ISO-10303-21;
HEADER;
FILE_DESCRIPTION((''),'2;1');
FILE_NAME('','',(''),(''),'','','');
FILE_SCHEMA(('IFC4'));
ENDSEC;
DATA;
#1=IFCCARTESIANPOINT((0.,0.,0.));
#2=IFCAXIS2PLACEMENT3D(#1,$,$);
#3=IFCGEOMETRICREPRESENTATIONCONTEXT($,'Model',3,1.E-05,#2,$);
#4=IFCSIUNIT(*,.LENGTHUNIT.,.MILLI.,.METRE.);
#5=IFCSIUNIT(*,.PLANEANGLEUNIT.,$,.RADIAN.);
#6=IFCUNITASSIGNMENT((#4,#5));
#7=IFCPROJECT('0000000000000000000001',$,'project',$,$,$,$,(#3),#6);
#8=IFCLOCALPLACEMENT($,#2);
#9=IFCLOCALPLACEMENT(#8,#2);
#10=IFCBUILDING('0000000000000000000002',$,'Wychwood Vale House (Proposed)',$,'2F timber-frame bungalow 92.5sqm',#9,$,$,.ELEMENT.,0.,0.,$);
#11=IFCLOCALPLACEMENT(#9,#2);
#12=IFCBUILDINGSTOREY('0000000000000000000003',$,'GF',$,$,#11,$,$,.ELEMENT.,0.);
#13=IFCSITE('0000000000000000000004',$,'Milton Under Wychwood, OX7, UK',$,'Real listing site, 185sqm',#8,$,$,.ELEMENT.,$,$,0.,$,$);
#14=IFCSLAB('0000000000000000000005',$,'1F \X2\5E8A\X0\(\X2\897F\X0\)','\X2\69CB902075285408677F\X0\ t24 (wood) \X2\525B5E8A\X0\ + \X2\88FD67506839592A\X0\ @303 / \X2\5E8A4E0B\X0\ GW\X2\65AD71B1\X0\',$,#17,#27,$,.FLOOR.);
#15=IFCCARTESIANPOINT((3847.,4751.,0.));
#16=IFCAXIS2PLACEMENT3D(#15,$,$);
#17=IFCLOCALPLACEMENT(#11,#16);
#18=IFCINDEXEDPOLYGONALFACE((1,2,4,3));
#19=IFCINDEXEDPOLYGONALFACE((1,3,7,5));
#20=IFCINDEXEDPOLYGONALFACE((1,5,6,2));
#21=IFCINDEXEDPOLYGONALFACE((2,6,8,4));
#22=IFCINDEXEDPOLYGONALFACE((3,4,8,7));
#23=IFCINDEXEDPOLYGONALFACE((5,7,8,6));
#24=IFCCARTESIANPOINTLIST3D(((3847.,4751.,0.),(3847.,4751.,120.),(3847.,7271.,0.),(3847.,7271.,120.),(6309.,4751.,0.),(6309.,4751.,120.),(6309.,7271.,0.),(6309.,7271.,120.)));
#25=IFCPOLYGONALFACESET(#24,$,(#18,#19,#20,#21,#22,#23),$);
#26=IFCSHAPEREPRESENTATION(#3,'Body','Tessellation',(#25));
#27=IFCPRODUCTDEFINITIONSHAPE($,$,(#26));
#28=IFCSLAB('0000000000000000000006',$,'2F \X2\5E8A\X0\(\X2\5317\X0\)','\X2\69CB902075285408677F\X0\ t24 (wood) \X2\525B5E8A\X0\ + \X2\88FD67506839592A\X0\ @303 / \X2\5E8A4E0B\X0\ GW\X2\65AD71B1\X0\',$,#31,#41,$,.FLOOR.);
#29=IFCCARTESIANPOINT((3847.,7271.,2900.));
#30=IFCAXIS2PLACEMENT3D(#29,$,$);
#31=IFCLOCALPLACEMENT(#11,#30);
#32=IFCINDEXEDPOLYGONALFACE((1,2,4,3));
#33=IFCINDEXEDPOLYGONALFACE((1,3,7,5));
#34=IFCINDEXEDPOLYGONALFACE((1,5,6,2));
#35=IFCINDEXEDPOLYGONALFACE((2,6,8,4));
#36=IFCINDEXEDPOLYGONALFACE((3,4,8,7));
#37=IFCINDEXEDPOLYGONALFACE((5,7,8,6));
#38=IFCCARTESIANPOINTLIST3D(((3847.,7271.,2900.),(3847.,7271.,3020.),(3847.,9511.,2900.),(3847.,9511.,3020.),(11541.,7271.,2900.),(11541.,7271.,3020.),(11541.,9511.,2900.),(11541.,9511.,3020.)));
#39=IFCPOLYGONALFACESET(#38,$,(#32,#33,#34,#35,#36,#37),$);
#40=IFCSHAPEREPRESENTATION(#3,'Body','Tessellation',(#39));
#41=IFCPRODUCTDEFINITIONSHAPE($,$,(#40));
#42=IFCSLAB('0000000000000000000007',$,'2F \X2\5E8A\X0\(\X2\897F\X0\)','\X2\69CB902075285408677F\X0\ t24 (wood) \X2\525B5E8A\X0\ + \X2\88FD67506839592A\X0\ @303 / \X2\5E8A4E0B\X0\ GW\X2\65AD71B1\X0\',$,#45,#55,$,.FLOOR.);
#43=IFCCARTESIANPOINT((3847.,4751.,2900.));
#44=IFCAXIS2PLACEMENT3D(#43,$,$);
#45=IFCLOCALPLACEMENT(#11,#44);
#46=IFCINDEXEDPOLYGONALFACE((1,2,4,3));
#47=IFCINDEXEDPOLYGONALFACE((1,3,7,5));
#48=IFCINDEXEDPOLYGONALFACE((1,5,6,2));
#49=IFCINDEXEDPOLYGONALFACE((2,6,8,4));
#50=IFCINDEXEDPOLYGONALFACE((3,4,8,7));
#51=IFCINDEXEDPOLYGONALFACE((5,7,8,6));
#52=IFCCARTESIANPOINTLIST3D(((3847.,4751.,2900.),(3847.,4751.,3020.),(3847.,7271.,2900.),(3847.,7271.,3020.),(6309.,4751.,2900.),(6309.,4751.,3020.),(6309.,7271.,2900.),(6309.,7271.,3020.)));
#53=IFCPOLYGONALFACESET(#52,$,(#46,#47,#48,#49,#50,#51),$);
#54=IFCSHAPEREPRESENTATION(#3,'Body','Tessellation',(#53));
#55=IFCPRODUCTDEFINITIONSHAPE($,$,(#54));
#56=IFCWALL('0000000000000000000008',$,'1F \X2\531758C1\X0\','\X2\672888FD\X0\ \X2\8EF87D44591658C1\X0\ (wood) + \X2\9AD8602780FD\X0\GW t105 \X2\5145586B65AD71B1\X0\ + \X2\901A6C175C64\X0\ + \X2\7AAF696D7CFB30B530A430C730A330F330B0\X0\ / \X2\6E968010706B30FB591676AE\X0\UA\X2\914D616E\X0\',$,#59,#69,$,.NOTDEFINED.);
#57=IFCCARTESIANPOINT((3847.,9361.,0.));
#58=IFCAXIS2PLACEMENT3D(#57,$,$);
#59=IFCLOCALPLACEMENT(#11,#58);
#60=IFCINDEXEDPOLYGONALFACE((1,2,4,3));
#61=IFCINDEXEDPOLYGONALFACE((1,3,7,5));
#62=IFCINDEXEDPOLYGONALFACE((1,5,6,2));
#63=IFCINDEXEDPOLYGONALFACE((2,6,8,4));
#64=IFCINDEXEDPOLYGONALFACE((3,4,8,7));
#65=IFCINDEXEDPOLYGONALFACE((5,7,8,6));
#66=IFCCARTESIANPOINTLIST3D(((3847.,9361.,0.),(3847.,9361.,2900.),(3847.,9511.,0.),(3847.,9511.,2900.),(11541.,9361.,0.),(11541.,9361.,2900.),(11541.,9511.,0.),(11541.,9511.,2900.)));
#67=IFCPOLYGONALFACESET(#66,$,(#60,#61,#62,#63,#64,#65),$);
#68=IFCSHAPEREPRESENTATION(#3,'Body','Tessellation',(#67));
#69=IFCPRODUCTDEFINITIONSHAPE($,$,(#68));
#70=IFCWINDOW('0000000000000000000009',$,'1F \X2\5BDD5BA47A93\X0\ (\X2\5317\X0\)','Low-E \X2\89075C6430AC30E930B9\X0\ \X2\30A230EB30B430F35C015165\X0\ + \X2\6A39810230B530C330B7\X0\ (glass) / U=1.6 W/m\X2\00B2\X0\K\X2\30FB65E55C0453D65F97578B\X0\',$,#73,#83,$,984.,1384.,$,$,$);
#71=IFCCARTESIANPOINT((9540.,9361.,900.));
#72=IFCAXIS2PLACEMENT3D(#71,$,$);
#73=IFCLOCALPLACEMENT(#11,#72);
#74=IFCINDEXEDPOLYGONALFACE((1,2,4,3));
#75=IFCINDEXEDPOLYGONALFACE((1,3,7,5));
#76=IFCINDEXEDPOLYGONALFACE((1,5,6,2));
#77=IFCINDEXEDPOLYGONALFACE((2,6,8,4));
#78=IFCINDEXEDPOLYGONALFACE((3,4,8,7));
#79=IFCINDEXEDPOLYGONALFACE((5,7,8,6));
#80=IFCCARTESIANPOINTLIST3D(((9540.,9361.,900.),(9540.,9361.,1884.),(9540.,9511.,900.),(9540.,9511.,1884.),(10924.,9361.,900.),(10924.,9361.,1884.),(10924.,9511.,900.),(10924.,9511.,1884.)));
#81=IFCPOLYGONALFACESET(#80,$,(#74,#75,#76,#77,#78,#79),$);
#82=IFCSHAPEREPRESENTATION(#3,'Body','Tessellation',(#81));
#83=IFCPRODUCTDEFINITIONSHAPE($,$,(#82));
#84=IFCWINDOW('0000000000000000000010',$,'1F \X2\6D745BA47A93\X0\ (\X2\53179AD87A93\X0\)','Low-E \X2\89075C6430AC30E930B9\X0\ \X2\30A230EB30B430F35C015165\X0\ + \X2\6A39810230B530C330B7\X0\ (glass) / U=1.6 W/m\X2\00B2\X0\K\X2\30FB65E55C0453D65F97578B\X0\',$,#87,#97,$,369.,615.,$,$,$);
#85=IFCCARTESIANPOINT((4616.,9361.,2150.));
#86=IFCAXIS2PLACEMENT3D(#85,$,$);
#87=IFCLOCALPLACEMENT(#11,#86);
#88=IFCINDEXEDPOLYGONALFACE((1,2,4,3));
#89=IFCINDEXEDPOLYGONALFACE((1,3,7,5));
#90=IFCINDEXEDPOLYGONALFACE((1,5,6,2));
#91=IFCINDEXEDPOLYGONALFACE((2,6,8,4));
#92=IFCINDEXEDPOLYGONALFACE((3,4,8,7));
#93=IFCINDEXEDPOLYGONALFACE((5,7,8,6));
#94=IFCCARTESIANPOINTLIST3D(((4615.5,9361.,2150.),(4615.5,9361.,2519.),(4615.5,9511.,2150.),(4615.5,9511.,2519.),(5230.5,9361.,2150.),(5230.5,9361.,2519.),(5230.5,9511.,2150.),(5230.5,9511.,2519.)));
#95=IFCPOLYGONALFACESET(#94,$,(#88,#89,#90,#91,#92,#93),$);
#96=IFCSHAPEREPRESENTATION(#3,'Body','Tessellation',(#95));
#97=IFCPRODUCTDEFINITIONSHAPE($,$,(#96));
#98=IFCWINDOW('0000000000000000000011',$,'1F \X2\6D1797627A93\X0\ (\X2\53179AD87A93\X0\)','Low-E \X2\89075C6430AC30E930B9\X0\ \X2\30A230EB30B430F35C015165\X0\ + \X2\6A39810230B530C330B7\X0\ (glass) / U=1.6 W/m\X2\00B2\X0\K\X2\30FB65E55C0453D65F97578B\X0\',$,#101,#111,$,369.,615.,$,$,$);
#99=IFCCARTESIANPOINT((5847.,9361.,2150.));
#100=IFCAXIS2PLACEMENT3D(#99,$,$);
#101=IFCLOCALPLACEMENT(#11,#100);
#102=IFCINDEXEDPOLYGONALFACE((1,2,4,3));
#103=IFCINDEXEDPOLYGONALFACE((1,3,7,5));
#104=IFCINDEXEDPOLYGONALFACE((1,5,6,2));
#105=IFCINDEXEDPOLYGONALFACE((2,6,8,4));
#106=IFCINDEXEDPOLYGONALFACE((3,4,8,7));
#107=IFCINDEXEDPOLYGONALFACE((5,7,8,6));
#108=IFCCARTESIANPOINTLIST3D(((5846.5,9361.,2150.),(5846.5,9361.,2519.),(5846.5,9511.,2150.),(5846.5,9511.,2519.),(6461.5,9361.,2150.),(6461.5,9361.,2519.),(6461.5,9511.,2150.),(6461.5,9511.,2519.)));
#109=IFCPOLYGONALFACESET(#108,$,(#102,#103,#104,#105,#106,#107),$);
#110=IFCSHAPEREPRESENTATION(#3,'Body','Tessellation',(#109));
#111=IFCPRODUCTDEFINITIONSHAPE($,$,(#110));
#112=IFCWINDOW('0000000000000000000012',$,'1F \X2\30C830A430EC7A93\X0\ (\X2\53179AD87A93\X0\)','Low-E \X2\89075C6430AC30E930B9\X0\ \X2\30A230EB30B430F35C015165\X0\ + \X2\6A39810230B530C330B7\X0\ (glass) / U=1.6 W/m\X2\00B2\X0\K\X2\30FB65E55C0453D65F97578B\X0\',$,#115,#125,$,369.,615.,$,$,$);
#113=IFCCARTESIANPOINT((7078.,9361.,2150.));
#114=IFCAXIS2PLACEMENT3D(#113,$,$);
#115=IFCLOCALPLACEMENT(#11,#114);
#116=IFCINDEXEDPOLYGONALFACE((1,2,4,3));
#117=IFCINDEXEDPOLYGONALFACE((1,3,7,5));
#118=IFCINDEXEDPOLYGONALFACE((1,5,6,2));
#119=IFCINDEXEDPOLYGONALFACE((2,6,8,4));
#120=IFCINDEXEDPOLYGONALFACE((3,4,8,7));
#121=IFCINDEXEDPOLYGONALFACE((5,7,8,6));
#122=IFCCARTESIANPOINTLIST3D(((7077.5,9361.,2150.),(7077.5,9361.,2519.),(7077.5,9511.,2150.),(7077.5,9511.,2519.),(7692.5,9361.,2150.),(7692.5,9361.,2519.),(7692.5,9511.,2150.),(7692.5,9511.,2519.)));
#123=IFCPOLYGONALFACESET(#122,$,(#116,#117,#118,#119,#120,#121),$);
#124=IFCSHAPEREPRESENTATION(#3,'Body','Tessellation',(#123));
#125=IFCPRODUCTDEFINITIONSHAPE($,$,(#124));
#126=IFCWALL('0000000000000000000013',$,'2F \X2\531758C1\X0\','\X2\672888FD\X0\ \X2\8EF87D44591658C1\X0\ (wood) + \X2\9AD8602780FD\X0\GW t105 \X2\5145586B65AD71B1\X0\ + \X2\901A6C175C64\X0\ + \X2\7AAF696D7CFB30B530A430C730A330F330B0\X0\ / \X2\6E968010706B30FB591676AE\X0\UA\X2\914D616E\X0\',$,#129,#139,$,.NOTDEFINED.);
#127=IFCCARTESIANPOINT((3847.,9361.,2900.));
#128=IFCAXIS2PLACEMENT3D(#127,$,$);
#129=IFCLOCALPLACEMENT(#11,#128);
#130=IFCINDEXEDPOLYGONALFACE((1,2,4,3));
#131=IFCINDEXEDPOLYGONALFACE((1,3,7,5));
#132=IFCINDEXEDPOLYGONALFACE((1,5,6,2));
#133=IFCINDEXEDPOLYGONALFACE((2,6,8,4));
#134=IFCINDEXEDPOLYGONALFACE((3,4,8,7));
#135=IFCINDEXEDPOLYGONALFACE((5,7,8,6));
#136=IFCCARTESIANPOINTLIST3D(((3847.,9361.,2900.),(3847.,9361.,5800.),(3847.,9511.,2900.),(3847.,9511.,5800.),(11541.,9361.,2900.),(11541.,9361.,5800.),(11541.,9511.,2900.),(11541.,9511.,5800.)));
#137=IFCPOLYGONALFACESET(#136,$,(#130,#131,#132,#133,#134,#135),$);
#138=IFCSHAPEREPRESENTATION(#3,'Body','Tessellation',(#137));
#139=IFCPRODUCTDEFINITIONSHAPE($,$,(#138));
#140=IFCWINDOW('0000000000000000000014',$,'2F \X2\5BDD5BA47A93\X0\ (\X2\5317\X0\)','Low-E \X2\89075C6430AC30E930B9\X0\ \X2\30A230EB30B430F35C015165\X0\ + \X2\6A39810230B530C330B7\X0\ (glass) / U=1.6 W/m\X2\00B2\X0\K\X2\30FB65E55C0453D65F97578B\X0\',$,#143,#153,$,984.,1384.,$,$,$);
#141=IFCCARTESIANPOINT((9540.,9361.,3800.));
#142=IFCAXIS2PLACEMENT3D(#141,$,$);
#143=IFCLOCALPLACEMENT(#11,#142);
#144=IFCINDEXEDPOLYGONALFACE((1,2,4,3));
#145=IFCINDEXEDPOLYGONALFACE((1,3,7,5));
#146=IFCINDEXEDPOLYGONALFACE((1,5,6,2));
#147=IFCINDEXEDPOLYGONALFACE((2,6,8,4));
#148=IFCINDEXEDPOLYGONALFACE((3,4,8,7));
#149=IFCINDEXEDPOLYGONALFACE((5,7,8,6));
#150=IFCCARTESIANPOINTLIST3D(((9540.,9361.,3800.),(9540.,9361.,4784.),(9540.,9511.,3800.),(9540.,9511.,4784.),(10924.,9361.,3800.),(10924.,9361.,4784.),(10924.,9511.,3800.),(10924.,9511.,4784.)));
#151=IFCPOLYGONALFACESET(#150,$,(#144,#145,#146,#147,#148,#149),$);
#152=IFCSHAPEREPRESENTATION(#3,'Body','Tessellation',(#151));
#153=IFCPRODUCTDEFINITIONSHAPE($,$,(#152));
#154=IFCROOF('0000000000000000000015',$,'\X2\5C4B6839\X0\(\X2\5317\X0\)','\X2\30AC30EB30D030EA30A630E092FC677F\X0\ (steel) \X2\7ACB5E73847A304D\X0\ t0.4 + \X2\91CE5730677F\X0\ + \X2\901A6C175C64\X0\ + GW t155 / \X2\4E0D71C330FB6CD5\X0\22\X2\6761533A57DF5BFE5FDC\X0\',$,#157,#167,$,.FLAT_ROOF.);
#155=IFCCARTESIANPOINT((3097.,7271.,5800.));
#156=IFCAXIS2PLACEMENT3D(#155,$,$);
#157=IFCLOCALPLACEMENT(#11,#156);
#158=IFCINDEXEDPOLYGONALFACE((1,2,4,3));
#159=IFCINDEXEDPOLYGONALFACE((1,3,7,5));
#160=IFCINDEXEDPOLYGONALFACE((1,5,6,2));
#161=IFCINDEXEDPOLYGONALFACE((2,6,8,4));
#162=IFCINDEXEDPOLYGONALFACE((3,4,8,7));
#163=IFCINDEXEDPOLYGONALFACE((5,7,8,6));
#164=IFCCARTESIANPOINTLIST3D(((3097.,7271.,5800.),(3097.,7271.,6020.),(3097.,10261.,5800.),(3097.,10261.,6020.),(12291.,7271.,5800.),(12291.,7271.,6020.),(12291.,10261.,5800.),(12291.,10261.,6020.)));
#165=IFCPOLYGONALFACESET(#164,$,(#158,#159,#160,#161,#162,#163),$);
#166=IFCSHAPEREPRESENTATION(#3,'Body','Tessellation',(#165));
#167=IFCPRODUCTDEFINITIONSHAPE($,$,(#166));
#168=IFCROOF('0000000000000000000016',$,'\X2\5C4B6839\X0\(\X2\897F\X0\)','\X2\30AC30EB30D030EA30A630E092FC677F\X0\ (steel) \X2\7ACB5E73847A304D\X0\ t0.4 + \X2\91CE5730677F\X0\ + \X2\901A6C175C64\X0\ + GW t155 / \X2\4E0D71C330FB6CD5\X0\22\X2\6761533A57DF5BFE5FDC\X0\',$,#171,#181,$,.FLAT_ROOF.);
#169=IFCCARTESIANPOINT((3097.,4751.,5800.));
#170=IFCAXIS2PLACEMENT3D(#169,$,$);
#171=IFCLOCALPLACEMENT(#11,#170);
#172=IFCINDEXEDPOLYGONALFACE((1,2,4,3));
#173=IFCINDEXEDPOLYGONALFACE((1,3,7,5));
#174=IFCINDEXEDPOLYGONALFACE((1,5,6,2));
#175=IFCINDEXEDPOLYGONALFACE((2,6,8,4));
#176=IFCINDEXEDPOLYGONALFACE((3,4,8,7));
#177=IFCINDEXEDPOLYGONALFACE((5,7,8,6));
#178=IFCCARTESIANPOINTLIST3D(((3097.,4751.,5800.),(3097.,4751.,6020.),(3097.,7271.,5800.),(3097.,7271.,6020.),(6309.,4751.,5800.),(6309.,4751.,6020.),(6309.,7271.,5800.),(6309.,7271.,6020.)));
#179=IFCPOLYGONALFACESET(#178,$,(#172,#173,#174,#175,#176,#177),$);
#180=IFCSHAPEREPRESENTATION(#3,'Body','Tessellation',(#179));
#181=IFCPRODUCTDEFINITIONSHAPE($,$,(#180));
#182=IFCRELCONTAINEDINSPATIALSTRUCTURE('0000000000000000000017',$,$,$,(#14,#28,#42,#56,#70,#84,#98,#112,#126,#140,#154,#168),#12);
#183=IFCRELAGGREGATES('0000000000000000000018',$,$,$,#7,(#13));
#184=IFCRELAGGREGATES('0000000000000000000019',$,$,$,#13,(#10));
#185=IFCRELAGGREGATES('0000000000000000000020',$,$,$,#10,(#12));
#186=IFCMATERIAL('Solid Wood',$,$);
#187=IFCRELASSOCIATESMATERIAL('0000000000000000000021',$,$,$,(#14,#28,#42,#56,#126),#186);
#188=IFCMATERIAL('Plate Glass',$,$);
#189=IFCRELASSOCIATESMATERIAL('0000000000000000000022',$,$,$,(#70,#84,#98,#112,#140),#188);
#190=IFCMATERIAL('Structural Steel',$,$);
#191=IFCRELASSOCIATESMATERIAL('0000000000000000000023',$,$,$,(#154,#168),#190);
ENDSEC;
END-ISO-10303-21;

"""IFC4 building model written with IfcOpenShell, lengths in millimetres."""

from ifc_helpers import new_model, si_unit, frame, frame_2d, origin, place, context, project, spatial, rectangle, extrude, material, element, fill, save


model = new_model("IFC4")

# Units and contexts
model_context = context("Model", 3, precision=1e-05, world=origin())
ifc_project = project(units=[si_unit("LENGTHUNIT", "METRE", prefix="MILLI"), si_unit("PLANEANGLEUNIT", "RADIAN")], contexts=[model_context])

# Site, building, storey
site_placement = place(None, origin())
site = spatial("IfcSite", under=ifc_project, at=site_placement, Name="Milton Under Wychwood, OX7, UK", ObjectType="Real listing site, 185sqm", CompositionType="ELEMENT", RefElevation=0.0)
building_placement = place(site_placement, origin())
building = spatial("IfcBuilding", under=site, at=building_placement, Name="Wychwood Vale House (Proposed)", ObjectType="2F timber-frame bungalow 92.5sqm", CompositionType="ELEMENT", ElevationOfRefHeight=0.0, ElevationOfTerrain=0.0)
storey_placement = place(building_placement, origin())
storey = spatial("IfcBuildingStorey", under=building, at=storey_placement, Name="GF", CompositionType="ELEMENT", Elevation=0.0)

# Slabs
ifc_material_1 = material(Name="Solid Wood")
slab_1_placement = place(storey_placement, frame((3847.0, 4751.0, 0.0)))
element("IfcSlab", 1, at=slab_1_placement, inside=storey, material=ifc_material_1, Name="1F 床(西)", Description="構造用合板 t24 (wood) 剛床 + 製材根太 @303 / 床下 GW断熱", PredefinedType="FLOOR", context=model_context, shape_type="SweptSolid", body=[
    extrude(rectangle(XDim=2462.0, YDim=2520.0, at=frame_2d((1231.0, 1260.0))), frame((3847.0, 4751.0, 0.0)), (0.0, 0.0, 1.0), 120.0),
])
slab_2_placement = place(storey_placement, frame((3847.0, 7271.0, 2900.0)))
element("IfcSlab", 2, at=slab_2_placement, inside=storey, material=ifc_material_1, Name="2F 床(北)", Description="構造用合板 t24 (wood) 剛床 + 製材根太 @303 / 床下 GW断熱", PredefinedType="FLOOR", context=model_context, shape_type="SweptSolid", body=[
    extrude(rectangle(XDim=7694.0, YDim=2240.0, at=frame_2d((3847.0, 1120.0))), frame((3847.0, 7271.0, 2900.0)), (0.0, 0.0, 1.0), 120.0),
])
slab_3_placement = place(storey_placement, frame((3847.0, 4751.0, 2900.0)))
element("IfcSlab", 3, at=slab_3_placement, inside=storey, material=ifc_material_1, Name="2F 床(西)", Description="構造用合板 t24 (wood) 剛床 + 製材根太 @303 / 床下 GW断熱", PredefinedType="FLOOR", context=model_context, shape_type="SweptSolid", body=[
    extrude(rectangle(XDim=2462.0, YDim=2520.0, at=frame_2d((1231.0, 1260.0))), frame((3847.0, 4751.0, 2900.0)), (0.0, 0.0, 1.0), 120.0),
])

# Wall, openings, windows
wall_1_placement = place(storey_placement, frame((3847.0, 9361.0, 0.0)))
wall_1 = element("IfcWall", 4, at=wall_1_placement, inside=storey, material=ifc_material_1, Name="1F 北壁", Description="木製 軸組外壁 (wood) + 高性能GW t105 充填断熱 + 通気層 + 窯業系サイディング / 準耐火・外皮UA配慮", PredefinedType="NOTDEFINED", context=model_context, shape_type="SweptSolid", body=[
    extrude(rectangle(XDim=7694.0, YDim=150.0, at=frame_2d((3847.0, 75.0))), frame((3847.0, 9361.0, 0.0)), (0.0, 0.0, 1.0), 2900.0),
])
opening_1_placement = place(storey_placement, frame((9540.0, 9361.0, 900.0)))
opening_1 = element("IfcOpeningElement", 5, at=opening_1_placement, cuts=wall_1, PredefinedType="NOTDEFINED", context=model_context, shape_type="SweptSolid", body=[
    extrude(rectangle(XDim=1384.0, YDim=150.0, at=frame_2d((692.0, 75.0))), frame((9540.0, 9361.0, 900.0)), (0.0, 0.0, 1.0), 984.0),
])
opening_2_placement = place(storey_placement, frame((4616.0, 9361.0, 2150.0)))
opening_2 = element("IfcOpeningElement", 6, at=opening_2_placement, cuts=wall_1, PredefinedType="NOTDEFINED", context=model_context, shape_type="SweptSolid", body=[
    extrude(rectangle(XDim=615.0, YDim=150.0, at=frame_2d((307.0, 75.0))), frame((4616.0, 9361.0, 2150.0)), (0.0, 0.0, 1.0), 369.0),
])
opening_3_placement = place(storey_placement, frame((5847.0, 9361.0, 2150.0)))
opening_3 = element("IfcOpeningElement", 7, at=opening_3_placement, cuts=wall_1, PredefinedType="NOTDEFINED", context=model_context, shape_type="SweptSolid", body=[
    extrude(rectangle(XDim=615.0, YDim=150.0, at=frame_2d((307.0, 75.0))), frame((5847.0, 9361.0, 2150.0)), (0.0, 0.0, 1.0), 369.0),
])
opening_4_placement = place(storey_placement, frame((7078.0, 9361.0, 2150.0)))
opening_4 = element("IfcOpeningElement", 8, at=opening_4_placement, cuts=wall_1, PredefinedType="NOTDEFINED", context=model_context, shape_type="SweptSolid", body=[
    extrude(rectangle(XDim=615.0, YDim=150.0, at=frame_2d((307.0, 75.0))), frame((7078.0, 9361.0, 2150.0)), (0.0, 0.0, 1.0), 369.0),
])
ifc_material_2 = material(Name="Plate Glass")
window_1_placement = place(storey_placement, frame((9540.0, 9361.0, 900.0)))
window_1 = element("IfcWindow", 9, at=window_1_placement, inside=storey, material=ifc_material_2, Name="1F 寝室窓 (北)", Description="Low-E 複層ガラス アルゴン封入 + 樹脂サッシ (glass) / U=1.6 W/m²K・日射取得型", OverallHeight=984.0, OverallWidth=1384.0, context=model_context, shape_type="SweptSolid", body=[
    extrude(rectangle(XDim=1384.0, YDim=150.0, at=frame_2d((692.0, 75.0))), frame((9540.0, 9361.0, 900.0)), (0.0, 0.0, 1.0), 984.0),
])
fill(opening_1, window_1)
window_2_placement = place(storey_placement, frame((4616.0, 9361.0, 2150.0)))
window_2 = element("IfcWindow", 10, at=window_2_placement, inside=storey, material=ifc_material_2, Name="1F 浴室窓 (北高窓)", Description="Low-E 複層ガラス アルゴン封入 + 樹脂サッシ (glass) / U=1.6 W/m²K・日射取得型", OverallHeight=369.0, OverallWidth=615.0, context=model_context, shape_type="SweptSolid", body=[
    extrude(rectangle(XDim=615.0, YDim=150.0, at=frame_2d((307.0, 75.0))), frame((4616.0, 9361.0, 2150.0)), (0.0, 0.0, 1.0), 369.0),
])
fill(opening_2, window_2)
window_3_placement = place(storey_placement, frame((5847.0, 9361.0, 2150.0)))
window_3 = element("IfcWindow", 11, at=window_3_placement, inside=storey, material=ifc_material_2, Name="1F 洗面窓 (北高窓)", Description="Low-E 複層ガラス アルゴン封入 + 樹脂サッシ (glass) / U=1.6 W/m²K・日射取得型", OverallHeight=369.0, OverallWidth=615.0, context=model_context, shape_type="SweptSolid", body=[
    extrude(rectangle(XDim=615.0, YDim=150.0, at=frame_2d((307.0, 75.0))), frame((5847.0, 9361.0, 2150.0)), (0.0, 0.0, 1.0), 369.0),
])
fill(opening_3, window_3)
window_4_placement = place(storey_placement, frame((7078.0, 9361.0, 2150.0)))
window_4 = element("IfcWindow", 12, at=window_4_placement, inside=storey, material=ifc_material_2, Name="1F トイレ窓 (北高窓)", Description="Low-E 複層ガラス アルゴン封入 + 樹脂サッシ (glass) / U=1.6 W/m²K・日射取得型", OverallHeight=369.0, OverallWidth=615.0, context=model_context, shape_type="SweptSolid", body=[
    extrude(rectangle(XDim=615.0, YDim=150.0, at=frame_2d((307.0, 75.0))), frame((7078.0, 9361.0, 2150.0)), (0.0, 0.0, 1.0), 369.0),
])
fill(opening_4, window_4)

# Wall, opening, window
wall_2_placement = place(storey_placement, frame((3847.0, 9361.0, 2900.0)))
wall_2 = element("IfcWall", 13, at=wall_2_placement, inside=storey, material=ifc_material_1, Name="2F 北壁", Description="木製 軸組外壁 (wood) + 高性能GW t105 充填断熱 + 通気層 + 窯業系サイディング / 準耐火・外皮UA配慮", PredefinedType="NOTDEFINED", context=model_context, shape_type="SweptSolid", body=[
    extrude(rectangle(XDim=7694.0, YDim=150.0, at=frame_2d((3847.0, 75.0))), frame((3847.0, 9361.0, 2900.0)), (0.0, 0.0, 1.0), 2900.0),
])
opening_5_placement = place(storey_placement, frame((9540.0, 9361.0, 3800.0)))
opening_5 = element("IfcOpeningElement", 14, at=opening_5_placement, cuts=wall_2, PredefinedType="NOTDEFINED", context=model_context, shape_type="SweptSolid", body=[
    extrude(rectangle(XDim=1384.0, YDim=150.0, at=frame_2d((692.0, 75.0))), frame((9540.0, 9361.0, 3800.0)), (0.0, 0.0, 1.0), 984.0),
])
window_5_placement = place(storey_placement, frame((9540.0, 9361.0, 3800.0)))
window_5 = element("IfcWindow", 15, at=window_5_placement, inside=storey, material=ifc_material_2, Name="2F 寝室窓 (北)", Description="Low-E 複層ガラス アルゴン封入 + 樹脂サッシ (glass) / U=1.6 W/m²K・日射取得型", OverallHeight=984.0, OverallWidth=1384.0, context=model_context, shape_type="SweptSolid", body=[
    extrude(rectangle(XDim=1384.0, YDim=150.0, at=frame_2d((692.0, 75.0))), frame((9540.0, 9361.0, 3800.0)), (0.0, 0.0, 1.0), 984.0),
])
fill(opening_5, window_5)

# Roofs
ifc_material_3 = material(Name="Structural Steel")
for number, where, name in (
    (16, (3097.0, 7271.0, 5800.0), "屋根(北)"),
):
    element("IfcRoof", number, at=place(storey_placement, frame(where)), inside=storey, material=ifc_material_3, Name=name, Description="ガルバリウム鋼板 (steel) 立平葺き t0.4 + 野地板 + 通気層 + GW t155 / 不燃・法22条区域対応", PredefinedType="FLAT_ROOF", context=model_context, shape_type="SweptSolid", body=[
        extrude(rectangle(XDim=9194.0, YDim=2990.0, at=frame_2d((4597.0, 1495.0))), frame((3097.0, 7271.0, 5800.0)), (0.0, 0.0, 1.0), 220.0),
    ])
roof_placement = place(storey_placement, frame((3097.0, 4751.0, 5800.0)))
element("IfcRoof", 17, at=roof_placement, inside=storey, material=ifc_material_3, Name="屋根(西)", Description="ガルバリウム鋼板 (steel) 立平葺き t0.4 + 野地板 + 通気層 + GW t155 / 不燃・法22条区域対応", PredefinedType="FLAT_ROOF", context=model_context, shape_type="SweptSolid", body=[
    extrude(rectangle(XDim=3212.0, YDim=2520.0, at=frame_2d((1606.0, 1260.0))), frame((3097.0, 4751.0, 5800.0)), (0.0, 0.0, 1.0), 220.0),
])

save(model, "model.ifc")
